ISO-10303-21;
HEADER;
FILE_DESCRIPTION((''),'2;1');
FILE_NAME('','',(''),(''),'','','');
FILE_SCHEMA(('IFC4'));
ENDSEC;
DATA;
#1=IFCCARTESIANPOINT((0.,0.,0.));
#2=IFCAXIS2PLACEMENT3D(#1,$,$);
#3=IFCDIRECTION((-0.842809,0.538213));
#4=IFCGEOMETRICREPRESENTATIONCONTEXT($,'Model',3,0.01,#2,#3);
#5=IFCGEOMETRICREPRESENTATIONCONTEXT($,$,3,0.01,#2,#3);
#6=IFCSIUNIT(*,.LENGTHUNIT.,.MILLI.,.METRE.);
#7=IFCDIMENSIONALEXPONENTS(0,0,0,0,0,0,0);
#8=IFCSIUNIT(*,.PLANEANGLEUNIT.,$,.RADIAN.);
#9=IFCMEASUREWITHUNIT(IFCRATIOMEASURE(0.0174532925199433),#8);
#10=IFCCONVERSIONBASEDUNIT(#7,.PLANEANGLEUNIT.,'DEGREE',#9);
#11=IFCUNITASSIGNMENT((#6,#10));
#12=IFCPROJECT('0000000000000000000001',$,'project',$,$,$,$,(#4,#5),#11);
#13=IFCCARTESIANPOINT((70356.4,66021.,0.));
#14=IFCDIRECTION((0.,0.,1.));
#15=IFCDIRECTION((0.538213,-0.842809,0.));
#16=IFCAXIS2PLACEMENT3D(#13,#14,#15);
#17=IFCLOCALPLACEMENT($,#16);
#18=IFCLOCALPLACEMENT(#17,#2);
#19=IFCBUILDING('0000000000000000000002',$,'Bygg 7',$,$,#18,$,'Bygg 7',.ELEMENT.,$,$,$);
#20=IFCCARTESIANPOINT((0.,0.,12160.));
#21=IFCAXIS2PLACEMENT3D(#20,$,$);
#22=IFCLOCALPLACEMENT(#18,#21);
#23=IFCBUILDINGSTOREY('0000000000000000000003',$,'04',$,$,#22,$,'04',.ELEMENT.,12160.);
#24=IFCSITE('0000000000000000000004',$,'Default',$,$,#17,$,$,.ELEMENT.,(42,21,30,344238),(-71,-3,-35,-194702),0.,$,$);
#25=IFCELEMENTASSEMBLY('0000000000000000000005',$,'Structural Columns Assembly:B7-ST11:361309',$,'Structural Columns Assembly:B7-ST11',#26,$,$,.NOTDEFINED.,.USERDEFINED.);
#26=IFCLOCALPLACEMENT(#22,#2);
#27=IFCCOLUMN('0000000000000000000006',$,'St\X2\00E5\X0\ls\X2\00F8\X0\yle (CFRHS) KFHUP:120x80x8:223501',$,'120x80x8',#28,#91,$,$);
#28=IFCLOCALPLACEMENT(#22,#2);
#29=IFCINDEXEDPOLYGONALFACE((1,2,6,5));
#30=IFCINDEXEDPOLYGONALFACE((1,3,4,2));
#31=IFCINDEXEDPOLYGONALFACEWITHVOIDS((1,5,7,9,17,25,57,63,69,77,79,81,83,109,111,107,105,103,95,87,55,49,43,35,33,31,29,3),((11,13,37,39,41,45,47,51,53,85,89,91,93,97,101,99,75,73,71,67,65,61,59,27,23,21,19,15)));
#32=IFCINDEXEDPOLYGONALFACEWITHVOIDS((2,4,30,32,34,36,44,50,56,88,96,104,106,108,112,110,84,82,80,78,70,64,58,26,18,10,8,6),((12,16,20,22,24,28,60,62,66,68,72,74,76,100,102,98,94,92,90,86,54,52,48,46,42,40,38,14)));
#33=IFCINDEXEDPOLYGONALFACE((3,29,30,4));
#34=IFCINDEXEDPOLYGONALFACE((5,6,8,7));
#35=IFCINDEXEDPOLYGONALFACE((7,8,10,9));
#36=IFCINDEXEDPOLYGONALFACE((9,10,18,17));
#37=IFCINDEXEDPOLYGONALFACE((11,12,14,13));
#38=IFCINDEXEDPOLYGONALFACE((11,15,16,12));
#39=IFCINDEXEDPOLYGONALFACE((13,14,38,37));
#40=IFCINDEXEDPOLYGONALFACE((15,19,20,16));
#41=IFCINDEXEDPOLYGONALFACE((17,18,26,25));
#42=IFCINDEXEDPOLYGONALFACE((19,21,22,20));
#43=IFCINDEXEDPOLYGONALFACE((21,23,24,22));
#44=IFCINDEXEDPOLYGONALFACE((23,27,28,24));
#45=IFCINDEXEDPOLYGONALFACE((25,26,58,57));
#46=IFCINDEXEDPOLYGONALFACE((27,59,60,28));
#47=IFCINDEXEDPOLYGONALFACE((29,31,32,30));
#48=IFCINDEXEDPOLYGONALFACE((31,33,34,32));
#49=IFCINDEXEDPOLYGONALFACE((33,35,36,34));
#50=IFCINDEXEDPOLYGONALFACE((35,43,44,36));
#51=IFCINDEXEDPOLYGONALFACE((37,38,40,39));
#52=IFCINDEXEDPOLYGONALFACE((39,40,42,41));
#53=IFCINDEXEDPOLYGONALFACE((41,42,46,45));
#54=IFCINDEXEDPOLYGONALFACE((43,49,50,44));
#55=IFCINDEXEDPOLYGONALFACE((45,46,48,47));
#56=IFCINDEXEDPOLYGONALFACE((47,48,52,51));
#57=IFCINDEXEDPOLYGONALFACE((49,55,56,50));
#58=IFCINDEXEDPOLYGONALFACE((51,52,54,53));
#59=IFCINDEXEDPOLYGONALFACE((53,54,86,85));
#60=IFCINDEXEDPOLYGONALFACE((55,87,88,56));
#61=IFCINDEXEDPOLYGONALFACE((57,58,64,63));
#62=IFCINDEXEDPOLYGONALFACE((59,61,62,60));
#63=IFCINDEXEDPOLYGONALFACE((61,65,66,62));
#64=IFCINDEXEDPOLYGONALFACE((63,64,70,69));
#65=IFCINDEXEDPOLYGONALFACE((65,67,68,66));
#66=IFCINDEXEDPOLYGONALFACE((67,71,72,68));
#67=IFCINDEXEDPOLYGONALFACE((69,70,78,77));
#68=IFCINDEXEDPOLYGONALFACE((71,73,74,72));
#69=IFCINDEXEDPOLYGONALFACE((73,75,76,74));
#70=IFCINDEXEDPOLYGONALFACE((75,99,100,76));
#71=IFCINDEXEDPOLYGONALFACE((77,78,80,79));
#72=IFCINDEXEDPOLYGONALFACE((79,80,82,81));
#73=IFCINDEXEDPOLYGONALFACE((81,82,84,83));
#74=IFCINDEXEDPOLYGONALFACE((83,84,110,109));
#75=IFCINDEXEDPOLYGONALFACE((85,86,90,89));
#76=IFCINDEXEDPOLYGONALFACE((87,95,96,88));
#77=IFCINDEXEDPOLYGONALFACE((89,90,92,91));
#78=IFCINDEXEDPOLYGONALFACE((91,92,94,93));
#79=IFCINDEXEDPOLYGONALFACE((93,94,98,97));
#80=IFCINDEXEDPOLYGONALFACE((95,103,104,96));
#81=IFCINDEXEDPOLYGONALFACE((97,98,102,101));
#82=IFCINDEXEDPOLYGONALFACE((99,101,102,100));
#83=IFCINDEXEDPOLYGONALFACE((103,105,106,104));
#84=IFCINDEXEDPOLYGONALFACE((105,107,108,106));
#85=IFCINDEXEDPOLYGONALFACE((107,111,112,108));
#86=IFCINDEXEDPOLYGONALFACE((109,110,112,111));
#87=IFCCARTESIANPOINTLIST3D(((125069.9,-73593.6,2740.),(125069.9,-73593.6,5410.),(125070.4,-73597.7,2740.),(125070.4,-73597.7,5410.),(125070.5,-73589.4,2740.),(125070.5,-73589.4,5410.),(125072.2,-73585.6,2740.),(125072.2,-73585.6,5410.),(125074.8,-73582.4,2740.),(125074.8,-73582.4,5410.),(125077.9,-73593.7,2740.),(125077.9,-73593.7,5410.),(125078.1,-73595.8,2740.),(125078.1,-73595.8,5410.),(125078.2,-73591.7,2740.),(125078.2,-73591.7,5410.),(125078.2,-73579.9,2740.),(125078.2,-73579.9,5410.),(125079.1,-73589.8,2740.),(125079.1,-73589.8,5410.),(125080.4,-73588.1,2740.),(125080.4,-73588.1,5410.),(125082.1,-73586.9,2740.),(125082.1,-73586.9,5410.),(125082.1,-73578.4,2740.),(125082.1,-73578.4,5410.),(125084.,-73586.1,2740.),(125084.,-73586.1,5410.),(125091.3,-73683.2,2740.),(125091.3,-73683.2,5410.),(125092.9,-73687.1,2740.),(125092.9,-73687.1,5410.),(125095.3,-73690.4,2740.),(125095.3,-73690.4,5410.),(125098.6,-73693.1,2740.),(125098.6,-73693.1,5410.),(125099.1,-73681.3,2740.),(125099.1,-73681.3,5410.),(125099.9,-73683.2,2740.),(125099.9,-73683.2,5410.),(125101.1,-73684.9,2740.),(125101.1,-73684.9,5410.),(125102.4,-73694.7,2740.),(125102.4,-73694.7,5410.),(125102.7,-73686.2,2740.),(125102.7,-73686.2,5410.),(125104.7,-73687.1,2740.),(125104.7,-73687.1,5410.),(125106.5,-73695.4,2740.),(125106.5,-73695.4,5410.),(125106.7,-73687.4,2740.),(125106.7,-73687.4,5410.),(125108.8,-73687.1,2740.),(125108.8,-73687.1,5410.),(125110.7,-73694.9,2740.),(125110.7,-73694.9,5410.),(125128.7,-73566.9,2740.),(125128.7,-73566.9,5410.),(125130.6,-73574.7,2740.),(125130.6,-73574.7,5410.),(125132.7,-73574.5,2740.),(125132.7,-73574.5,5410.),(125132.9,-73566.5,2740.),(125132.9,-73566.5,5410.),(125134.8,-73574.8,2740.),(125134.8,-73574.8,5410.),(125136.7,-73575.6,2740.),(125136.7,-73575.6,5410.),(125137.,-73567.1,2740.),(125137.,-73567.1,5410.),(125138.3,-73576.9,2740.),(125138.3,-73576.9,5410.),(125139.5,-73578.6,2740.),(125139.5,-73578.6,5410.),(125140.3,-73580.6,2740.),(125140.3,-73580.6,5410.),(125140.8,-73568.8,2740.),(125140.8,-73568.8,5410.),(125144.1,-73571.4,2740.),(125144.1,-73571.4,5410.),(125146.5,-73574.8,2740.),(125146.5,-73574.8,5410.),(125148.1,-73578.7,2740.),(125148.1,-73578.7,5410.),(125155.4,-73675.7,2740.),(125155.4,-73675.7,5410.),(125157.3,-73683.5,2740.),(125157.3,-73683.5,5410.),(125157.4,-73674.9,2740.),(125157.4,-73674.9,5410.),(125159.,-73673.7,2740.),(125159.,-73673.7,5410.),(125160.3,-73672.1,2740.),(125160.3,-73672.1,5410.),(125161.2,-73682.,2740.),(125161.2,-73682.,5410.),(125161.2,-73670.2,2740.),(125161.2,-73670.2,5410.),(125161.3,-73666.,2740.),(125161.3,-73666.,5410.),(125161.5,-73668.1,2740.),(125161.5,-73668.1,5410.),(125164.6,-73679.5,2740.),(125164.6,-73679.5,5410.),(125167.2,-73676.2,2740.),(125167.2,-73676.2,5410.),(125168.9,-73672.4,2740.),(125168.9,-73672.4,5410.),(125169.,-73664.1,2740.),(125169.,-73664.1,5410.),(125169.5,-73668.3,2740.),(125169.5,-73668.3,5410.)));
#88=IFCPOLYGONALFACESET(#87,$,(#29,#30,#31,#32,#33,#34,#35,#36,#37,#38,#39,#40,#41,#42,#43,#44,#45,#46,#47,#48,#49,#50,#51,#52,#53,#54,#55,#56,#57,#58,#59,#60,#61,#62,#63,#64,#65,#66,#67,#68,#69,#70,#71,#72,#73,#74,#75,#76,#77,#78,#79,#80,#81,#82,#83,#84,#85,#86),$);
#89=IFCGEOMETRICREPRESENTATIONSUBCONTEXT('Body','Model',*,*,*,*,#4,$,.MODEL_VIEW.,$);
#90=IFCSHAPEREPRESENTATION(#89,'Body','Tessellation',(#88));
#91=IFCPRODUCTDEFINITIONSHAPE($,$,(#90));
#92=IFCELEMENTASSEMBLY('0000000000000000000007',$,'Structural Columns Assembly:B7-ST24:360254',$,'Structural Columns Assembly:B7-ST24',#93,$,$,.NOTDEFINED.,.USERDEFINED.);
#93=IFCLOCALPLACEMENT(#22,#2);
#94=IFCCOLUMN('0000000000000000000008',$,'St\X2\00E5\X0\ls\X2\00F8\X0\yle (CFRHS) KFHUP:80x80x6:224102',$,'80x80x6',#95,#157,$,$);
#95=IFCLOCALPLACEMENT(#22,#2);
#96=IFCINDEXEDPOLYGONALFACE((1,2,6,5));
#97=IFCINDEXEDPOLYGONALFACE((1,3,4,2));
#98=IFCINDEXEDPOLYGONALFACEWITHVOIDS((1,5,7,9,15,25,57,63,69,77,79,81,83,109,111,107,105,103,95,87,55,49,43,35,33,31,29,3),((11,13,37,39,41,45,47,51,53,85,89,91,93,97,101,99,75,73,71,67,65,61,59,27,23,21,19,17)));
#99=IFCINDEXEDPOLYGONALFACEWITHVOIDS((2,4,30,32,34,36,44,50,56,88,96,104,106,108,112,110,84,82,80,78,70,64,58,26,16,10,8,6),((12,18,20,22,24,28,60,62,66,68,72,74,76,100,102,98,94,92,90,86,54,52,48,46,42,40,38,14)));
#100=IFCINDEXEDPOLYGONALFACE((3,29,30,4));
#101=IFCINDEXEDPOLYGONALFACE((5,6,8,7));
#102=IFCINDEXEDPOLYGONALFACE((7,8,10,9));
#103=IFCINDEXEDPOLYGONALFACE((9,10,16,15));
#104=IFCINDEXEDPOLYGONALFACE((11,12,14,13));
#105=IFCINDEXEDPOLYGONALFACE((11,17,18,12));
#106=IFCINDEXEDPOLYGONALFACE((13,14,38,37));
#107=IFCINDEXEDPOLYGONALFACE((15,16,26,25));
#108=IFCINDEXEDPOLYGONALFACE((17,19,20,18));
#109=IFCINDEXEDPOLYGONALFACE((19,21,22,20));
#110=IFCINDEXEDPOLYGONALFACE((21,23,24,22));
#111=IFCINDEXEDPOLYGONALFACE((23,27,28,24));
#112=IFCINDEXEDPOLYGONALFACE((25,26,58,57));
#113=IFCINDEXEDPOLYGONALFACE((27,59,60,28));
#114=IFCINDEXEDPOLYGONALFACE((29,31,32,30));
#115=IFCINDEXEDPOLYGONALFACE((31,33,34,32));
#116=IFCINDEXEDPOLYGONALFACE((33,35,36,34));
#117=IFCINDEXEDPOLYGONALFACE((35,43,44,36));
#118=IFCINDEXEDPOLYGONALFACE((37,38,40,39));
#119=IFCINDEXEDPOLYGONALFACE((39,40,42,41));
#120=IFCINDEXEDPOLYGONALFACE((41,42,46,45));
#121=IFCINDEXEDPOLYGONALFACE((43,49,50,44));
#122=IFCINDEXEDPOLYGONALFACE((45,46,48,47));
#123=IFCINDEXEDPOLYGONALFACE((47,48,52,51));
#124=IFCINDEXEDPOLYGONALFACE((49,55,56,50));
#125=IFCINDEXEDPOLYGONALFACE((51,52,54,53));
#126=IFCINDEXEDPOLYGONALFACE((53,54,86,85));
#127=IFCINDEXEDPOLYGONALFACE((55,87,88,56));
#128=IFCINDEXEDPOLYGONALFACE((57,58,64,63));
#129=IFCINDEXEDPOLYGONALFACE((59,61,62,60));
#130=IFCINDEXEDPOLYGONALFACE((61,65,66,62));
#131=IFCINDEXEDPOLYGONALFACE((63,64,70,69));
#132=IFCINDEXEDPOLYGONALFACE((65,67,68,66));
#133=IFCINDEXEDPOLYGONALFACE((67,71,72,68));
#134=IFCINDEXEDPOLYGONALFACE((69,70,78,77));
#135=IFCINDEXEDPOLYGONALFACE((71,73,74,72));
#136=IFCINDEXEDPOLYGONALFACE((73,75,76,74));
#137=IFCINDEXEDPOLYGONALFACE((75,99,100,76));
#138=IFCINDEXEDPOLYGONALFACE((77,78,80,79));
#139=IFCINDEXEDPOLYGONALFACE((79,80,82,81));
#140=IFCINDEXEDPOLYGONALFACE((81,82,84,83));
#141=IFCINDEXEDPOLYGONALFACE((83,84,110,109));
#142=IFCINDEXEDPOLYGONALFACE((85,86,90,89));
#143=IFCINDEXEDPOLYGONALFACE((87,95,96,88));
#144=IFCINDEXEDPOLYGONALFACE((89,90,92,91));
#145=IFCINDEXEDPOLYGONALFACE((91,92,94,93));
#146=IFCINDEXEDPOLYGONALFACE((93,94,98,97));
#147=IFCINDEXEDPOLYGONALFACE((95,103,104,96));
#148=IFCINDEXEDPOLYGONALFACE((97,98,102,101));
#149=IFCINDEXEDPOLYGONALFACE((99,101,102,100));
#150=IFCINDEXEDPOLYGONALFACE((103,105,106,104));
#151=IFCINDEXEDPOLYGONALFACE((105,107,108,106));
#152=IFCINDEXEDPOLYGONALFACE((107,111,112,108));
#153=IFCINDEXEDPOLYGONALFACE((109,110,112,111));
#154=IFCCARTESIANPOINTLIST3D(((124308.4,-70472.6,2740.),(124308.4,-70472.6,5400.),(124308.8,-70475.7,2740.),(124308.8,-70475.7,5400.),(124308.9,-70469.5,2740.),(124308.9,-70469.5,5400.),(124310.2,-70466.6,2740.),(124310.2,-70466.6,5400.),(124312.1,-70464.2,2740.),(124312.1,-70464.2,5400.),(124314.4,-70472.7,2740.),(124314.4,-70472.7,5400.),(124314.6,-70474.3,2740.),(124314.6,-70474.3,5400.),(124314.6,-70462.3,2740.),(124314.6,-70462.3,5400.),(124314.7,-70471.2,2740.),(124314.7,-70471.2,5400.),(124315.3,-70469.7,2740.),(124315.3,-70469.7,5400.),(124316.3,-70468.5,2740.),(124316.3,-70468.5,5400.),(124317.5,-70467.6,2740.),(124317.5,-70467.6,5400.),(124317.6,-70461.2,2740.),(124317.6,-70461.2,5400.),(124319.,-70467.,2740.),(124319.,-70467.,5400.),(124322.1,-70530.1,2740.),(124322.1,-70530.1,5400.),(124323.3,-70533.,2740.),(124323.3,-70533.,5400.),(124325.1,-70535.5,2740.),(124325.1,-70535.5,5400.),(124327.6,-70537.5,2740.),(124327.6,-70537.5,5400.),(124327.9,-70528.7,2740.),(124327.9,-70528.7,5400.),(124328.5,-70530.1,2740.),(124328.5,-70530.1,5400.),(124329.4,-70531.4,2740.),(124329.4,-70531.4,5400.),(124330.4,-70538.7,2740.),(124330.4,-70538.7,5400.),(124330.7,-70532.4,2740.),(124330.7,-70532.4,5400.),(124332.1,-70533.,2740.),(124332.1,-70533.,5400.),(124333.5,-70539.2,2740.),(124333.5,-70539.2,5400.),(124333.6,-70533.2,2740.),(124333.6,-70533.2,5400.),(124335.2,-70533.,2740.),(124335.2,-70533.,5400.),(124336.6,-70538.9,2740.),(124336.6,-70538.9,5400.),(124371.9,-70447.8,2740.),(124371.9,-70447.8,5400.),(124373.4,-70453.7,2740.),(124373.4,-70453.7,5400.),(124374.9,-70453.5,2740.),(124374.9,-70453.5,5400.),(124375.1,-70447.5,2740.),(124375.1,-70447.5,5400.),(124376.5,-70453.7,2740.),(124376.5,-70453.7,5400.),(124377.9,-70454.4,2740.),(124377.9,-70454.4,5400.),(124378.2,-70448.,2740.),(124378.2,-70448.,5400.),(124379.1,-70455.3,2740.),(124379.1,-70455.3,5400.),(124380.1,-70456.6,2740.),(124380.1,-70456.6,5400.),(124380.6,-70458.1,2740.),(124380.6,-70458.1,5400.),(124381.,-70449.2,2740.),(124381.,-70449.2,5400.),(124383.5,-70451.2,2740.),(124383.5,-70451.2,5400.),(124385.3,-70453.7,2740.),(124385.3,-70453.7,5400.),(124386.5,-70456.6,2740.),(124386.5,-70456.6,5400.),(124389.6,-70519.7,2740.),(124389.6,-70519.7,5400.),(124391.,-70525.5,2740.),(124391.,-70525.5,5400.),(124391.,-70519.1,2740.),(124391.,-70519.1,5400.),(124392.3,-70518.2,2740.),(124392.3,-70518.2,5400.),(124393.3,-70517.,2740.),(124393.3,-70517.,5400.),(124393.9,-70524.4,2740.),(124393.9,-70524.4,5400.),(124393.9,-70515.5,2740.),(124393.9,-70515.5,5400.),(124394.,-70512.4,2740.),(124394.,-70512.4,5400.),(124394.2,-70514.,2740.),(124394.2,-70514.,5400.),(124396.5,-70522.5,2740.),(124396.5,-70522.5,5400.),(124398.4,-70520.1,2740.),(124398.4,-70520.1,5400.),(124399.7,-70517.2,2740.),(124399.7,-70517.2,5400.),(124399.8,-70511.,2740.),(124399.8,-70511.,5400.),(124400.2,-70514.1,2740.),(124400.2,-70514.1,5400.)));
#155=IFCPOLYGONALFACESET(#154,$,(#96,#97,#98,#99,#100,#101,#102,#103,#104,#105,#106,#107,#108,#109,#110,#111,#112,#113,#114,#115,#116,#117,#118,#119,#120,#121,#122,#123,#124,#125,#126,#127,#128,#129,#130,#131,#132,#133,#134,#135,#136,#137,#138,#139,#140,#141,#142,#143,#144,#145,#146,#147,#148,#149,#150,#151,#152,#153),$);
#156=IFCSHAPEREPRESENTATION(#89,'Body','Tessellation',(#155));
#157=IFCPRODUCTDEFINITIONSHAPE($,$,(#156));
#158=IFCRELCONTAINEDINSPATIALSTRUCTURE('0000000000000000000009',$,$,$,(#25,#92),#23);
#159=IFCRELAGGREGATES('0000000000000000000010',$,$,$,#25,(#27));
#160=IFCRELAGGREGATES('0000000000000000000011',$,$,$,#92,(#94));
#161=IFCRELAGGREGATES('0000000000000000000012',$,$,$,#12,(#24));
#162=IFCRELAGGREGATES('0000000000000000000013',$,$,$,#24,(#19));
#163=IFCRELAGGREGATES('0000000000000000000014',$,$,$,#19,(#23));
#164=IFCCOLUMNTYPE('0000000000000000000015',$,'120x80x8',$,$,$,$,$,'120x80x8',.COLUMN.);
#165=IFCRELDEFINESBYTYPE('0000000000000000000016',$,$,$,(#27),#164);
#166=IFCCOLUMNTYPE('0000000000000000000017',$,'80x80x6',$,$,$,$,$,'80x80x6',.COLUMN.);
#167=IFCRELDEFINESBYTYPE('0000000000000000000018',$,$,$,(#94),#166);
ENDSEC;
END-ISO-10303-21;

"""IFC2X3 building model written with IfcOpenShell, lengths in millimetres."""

from ifc_helpers import new_model, entity, si_unit, converted_unit, direction, frame, frame_2d, origin, place, context, subcontext, project, spatial, polyline, circle_curve, parameter, trimmed, segment, composite_curve, outline, extrude, source, transform, mapped, type_object, type_shapes, element, aggregate, save


model = new_model("IFC2X3")

# Units and contexts
model_context = context("Model", 3, precision=0.01, world=origin(), true_north=direction((-0.842809, 0.538213)))
context_of_model = context(None, 3, precision=0.01, world=origin(), true_north=direction((-0.842809, 0.538213)))
body_context = subcontext(model_context, "Body", "Model", "MODEL_VIEW")
ifc_project = project(units=[si_unit("LENGTHUNIT", "METRE", prefix="MILLI"), converted_unit("PLANEANGLEUNIT", "DEGREE", entity("IfcRatioMeasure", 0.0174532925199433), si_unit("PLANEANGLEUNIT", "RADIAN"), dimensions=[0, 0, 0, 0, 0, 0, 0])], contexts=[model_context, context_of_model])

# Site, building, storey
site_placement = place(None, frame((70356.4, 66021.0, 0.0), z_axis=(0.0, 0.0, 1.0), x_axis=(0.538213, -0.842809, 0.0)))
site = spatial("IfcSite", under=ifc_project, at=site_placement, Name="Default", CompositionType="ELEMENT", RefLatitude=(42, 21, 30, 344238), RefLongitude=(-71, -3, -35, -194702), RefElevation=0.0)
building_placement = place(site_placement, origin())
building = spatial("IfcBuilding", under=site, at=building_placement, Name="Bygg 7", LongName="Bygg 7", CompositionType="ELEMENT")
storey_placement = place(building_placement, frame((0.0, 0.0, 12160.0)))
storey = spatial("IfcBuildingStorey", under=building, at=storey_placement, Name="04", LongName="04", CompositionType="ELEMENT", Elevation=12160.0)

# Element assemblies, columns
assembly_1_placement = place(storey_placement, origin())
assembly_1 = element("IfcElementAssembly", 1, at=assembly_1_placement, inside=storey, Name="Structural Columns Assembly:B7-ST11:361309", ObjectType="Structural Columns Assembly:B7-ST11", AssemblyPlace="NOTDEFINED", PredefinedType="USERDEFINED")
column_type_1 = type_object("IfcColumnType", Name="120x80x8", ElementType="120x80x8", PredefinedType="COLUMN")
shared_shape_1 = source(origin(), body_context, "Body", "SweptSolid", [
    extrude(outline(composite_curve([segment(trimmed(circle_curve(frame_2d((-24.0, 44.0), x_axis=(1.0, 0.0)), 16.0), [parameter(90.0)], [parameter(180.0)], True, "PARAMETER"), True, "CONTINUOUS"), segment(polyline([(-40.0, 44.0), (-40.0, -44.0)]), True, "CONTINUOUS"), segment(trimmed(circle_curve(frame_2d((-24.0, -44.0), x_axis=(1.0, 0.0)), 16.0), [parameter(180.0)], [parameter(270.0)], True, "PARAMETER"), True, "CONTINUOUS"), segment(polyline([(-24.0, -60.0), (24.0, -60.0)]), True, "CONTINUOUS"), segment(trimmed(circle_curve(frame_2d((24.0, -44.0), x_axis=(1.0, 0.0)), 16.0), [parameter(270.0)], [parameter(0.0)], True, "PARAMETER"), True, "CONTINUOUS"), segment(polyline([(40.0, -44.0), (40.0, 44.0)]), True, "CONTINUOUS"), segment(trimmed(circle_curve(frame_2d((24.0, 44.0), x_axis=(1.0, 0.0)), 16.0), [parameter(0.0)], [parameter(90.0)], True, "PARAMETER"), True, "CONTINUOUS"), segment(polyline([(24.0, 60.0), (-24.0, 60.0)]), True, "CONTINUOUS")], self_intersect=False), holes=[composite_curve([segment(polyline([(-24.0, 52.0), (24.0, 52.0)]), True, "CONTINUOUS"), segment(trimmed(circle_curve(frame_2d((24.0, 44.0), x_axis=(1.0, 0.0)), 8.0), [parameter(360.0)], [parameter(90.0)], True, "PARAMETER"), False, "CONTINUOUS"), segment(polyline([(32.0, 44.0), (32.0, -44.0)]), True, "CONTINUOUS"), segment(trimmed(circle_curve(frame_2d((24.0, -44.0), x_axis=(1.0, 0.0)), 8.0), [parameter(270.0)], [parameter(360.0)], True, "PARAMETER"), False, "CONTINUOUS"), segment(polyline([(24.0, -52.0), (-24.0, -52.0)]), True, "CONTINUOUS"), segment(trimmed(circle_curve(frame_2d((-24.0, -44.0), x_axis=(1.0, 0.0)), 8.0), [parameter(180.0)], [parameter(270.0)], True, "PARAMETER"), False, "CONTINUOUS"), segment(polyline([(-32.0, -44.0), (-32.0, 44.0)]), True, "CONTINUOUS"), segment(trimmed(circle_curve(frame_2d((-24.0, 44.0), x_axis=(1.0, 0.0)), 8.0), [parameter(90.0)], [parameter(180.0)], True, "PARAMETER"), False, "CONTINUOUS")], self_intersect=False)]), frame((51.4, 66.0, 0.0), z_axis=(0.0, 0.0, 1.0), x_axis=(-0.971172, -0.238381, 0.0)), (0.0, 0.0, 1.0), 2670.0),
])
type_shapes(column_type_1, [shared_shape_1])
column_1_placement = place(assembly_1_placement, frame((125068.3, -73697.0, 2740.0)))
column_1 = element("IfcColumn", 2, at=column_1_placement, type_object=column_type_1, Name="Stålsøyle (CFRHS) KFHUP:120x80x8:223501", ObjectType="120x80x8", context=body_context, shape_type="MappedRepresentation", body=[
    mapped(shared_shape_1, transform((0.0, 0.0, 0.0), scale=1.0)),
])
aggregate(assembly_1, [column_1])
assembly_2_placement = place(storey_placement, origin())
assembly_2 = element("IfcElementAssembly", 3, at=assembly_2_placement, inside=storey, Name="Structural Columns Assembly:B7-ST24:360254", ObjectType="Structural Columns Assembly:B7-ST24", AssemblyPlace="NOTDEFINED", PredefinedType="USERDEFINED")
column_type_2 = type_object("IfcColumnType", Name="80x80x6", ElementType="80x80x6", PredefinedType="COLUMN")
shared_shape_2 = source(origin(), body_context, "Body", "SweptSolid", [
    extrude(outline(composite_curve([segment(trimmed(circle_curve(frame_2d((-28.0, 28.0), x_axis=(1.0, 0.0)), 12.0), [parameter(90.0)], [parameter(180.0)], True, "PARAMETER"), True, "CONTINUOUS"), segment(polyline([(-40.0, 28.0), (-40.0, -28.0)]), True, "CONTINUOUS"), segment(trimmed(circle_curve(frame_2d((-28.0, -28.0), x_axis=(1.0, 0.0)), 12.0), [parameter(180.0)], [parameter(270.0)], True, "PARAMETER"), True, "CONTINUOUS"), segment(polyline([(-28.0, -40.0), (28.0, -40.0)]), True, "CONTINUOUS"), segment(trimmed(circle_curve(frame_2d((28.0, -28.0), x_axis=(1.0, 0.0)), 12.0), [parameter(270.0)], [parameter(0.0)], True, "PARAMETER"), True, "CONTINUOUS"), segment(polyline([(40.0, -28.0), (40.0, 28.0)]), True, "CONTINUOUS"), segment(trimmed(circle_curve(frame_2d((28.0, 28.0), x_axis=(1.0, 0.0)), 12.0), [parameter(0.0)], [parameter(90.0)], True, "PARAMETER"), True, "CONTINUOUS"), segment(polyline([(28.0, 40.0), (-28.0, 40.0)]), True, "CONTINUOUS")], self_intersect=False), holes=[composite_curve([segment(polyline([(-28.0, 34.0), (28.0, 34.0)]), True, "CONTINUOUS"), segment(trimmed(circle_curve(frame_2d((28.0, 28.0), x_axis=(1.0, 0.0)), 6.0), [parameter(360.0)], [parameter(90.0)], True, "PARAMETER"), False, "CONTINUOUS"), segment(polyline([(34.0, 28.0), (34.0, -28.0)]), True, "CONTINUOUS"), segment(trimmed(circle_curve(frame_2d((28.0, -28.0), x_axis=(1.0, 0.0)), 6.0), [parameter(270.0)], [parameter(360.0)], True, "PARAMETER"), False, "CONTINUOUS"), segment(polyline([(28.0, -34.0), (-28.0, -34.0)]), True, "CONTINUOUS"), segment(trimmed(circle_curve(frame_2d((-28.0, -28.0), x_axis=(1.0, 0.0)), 6.0), [parameter(180.0)], [parameter(270.0)], True, "PARAMETER"), False, "CONTINUOUS"), segment(polyline([(-34.0, -28.0), (-34.0, 28.0)]), True, "CONTINUOUS"), segment(trimmed(circle_curve(frame_2d((-28.0, 28.0), x_axis=(1.0, 0.0)), 6.0), [parameter(90.0)], [parameter(180.0)], True, "PARAMETER"), False, "CONTINUOUS")], self_intersect=False)]), frame((47.5, 47.5, 0.0), z_axis=(0.0, 0.0, 1.0), x_axis=(-0.971172, -0.238381, 0.0)), (0.0, 0.0, 1.0), 2660.0),
])
type_shapes(column_type_2, [shared_shape_2])
column_2_placement = place(assembly_2_placement, frame((124306.8, -70540.8, 2740.0)))
column_2 = element("IfcColumn", 4, at=column_2_placement, type_object=column_type_2, Name="Stålsøyle (CFRHS) KFHUP:80x80x6:224102", ObjectType="80x80x6", context=body_context, shape_type="MappedRepresentation", body=[
    mapped(shared_shape_2, transform((0.0, 0.0, 0.0), scale=1.0)),
])
aggregate(assembly_2, [column_2])

save(model, "model.ifc")
